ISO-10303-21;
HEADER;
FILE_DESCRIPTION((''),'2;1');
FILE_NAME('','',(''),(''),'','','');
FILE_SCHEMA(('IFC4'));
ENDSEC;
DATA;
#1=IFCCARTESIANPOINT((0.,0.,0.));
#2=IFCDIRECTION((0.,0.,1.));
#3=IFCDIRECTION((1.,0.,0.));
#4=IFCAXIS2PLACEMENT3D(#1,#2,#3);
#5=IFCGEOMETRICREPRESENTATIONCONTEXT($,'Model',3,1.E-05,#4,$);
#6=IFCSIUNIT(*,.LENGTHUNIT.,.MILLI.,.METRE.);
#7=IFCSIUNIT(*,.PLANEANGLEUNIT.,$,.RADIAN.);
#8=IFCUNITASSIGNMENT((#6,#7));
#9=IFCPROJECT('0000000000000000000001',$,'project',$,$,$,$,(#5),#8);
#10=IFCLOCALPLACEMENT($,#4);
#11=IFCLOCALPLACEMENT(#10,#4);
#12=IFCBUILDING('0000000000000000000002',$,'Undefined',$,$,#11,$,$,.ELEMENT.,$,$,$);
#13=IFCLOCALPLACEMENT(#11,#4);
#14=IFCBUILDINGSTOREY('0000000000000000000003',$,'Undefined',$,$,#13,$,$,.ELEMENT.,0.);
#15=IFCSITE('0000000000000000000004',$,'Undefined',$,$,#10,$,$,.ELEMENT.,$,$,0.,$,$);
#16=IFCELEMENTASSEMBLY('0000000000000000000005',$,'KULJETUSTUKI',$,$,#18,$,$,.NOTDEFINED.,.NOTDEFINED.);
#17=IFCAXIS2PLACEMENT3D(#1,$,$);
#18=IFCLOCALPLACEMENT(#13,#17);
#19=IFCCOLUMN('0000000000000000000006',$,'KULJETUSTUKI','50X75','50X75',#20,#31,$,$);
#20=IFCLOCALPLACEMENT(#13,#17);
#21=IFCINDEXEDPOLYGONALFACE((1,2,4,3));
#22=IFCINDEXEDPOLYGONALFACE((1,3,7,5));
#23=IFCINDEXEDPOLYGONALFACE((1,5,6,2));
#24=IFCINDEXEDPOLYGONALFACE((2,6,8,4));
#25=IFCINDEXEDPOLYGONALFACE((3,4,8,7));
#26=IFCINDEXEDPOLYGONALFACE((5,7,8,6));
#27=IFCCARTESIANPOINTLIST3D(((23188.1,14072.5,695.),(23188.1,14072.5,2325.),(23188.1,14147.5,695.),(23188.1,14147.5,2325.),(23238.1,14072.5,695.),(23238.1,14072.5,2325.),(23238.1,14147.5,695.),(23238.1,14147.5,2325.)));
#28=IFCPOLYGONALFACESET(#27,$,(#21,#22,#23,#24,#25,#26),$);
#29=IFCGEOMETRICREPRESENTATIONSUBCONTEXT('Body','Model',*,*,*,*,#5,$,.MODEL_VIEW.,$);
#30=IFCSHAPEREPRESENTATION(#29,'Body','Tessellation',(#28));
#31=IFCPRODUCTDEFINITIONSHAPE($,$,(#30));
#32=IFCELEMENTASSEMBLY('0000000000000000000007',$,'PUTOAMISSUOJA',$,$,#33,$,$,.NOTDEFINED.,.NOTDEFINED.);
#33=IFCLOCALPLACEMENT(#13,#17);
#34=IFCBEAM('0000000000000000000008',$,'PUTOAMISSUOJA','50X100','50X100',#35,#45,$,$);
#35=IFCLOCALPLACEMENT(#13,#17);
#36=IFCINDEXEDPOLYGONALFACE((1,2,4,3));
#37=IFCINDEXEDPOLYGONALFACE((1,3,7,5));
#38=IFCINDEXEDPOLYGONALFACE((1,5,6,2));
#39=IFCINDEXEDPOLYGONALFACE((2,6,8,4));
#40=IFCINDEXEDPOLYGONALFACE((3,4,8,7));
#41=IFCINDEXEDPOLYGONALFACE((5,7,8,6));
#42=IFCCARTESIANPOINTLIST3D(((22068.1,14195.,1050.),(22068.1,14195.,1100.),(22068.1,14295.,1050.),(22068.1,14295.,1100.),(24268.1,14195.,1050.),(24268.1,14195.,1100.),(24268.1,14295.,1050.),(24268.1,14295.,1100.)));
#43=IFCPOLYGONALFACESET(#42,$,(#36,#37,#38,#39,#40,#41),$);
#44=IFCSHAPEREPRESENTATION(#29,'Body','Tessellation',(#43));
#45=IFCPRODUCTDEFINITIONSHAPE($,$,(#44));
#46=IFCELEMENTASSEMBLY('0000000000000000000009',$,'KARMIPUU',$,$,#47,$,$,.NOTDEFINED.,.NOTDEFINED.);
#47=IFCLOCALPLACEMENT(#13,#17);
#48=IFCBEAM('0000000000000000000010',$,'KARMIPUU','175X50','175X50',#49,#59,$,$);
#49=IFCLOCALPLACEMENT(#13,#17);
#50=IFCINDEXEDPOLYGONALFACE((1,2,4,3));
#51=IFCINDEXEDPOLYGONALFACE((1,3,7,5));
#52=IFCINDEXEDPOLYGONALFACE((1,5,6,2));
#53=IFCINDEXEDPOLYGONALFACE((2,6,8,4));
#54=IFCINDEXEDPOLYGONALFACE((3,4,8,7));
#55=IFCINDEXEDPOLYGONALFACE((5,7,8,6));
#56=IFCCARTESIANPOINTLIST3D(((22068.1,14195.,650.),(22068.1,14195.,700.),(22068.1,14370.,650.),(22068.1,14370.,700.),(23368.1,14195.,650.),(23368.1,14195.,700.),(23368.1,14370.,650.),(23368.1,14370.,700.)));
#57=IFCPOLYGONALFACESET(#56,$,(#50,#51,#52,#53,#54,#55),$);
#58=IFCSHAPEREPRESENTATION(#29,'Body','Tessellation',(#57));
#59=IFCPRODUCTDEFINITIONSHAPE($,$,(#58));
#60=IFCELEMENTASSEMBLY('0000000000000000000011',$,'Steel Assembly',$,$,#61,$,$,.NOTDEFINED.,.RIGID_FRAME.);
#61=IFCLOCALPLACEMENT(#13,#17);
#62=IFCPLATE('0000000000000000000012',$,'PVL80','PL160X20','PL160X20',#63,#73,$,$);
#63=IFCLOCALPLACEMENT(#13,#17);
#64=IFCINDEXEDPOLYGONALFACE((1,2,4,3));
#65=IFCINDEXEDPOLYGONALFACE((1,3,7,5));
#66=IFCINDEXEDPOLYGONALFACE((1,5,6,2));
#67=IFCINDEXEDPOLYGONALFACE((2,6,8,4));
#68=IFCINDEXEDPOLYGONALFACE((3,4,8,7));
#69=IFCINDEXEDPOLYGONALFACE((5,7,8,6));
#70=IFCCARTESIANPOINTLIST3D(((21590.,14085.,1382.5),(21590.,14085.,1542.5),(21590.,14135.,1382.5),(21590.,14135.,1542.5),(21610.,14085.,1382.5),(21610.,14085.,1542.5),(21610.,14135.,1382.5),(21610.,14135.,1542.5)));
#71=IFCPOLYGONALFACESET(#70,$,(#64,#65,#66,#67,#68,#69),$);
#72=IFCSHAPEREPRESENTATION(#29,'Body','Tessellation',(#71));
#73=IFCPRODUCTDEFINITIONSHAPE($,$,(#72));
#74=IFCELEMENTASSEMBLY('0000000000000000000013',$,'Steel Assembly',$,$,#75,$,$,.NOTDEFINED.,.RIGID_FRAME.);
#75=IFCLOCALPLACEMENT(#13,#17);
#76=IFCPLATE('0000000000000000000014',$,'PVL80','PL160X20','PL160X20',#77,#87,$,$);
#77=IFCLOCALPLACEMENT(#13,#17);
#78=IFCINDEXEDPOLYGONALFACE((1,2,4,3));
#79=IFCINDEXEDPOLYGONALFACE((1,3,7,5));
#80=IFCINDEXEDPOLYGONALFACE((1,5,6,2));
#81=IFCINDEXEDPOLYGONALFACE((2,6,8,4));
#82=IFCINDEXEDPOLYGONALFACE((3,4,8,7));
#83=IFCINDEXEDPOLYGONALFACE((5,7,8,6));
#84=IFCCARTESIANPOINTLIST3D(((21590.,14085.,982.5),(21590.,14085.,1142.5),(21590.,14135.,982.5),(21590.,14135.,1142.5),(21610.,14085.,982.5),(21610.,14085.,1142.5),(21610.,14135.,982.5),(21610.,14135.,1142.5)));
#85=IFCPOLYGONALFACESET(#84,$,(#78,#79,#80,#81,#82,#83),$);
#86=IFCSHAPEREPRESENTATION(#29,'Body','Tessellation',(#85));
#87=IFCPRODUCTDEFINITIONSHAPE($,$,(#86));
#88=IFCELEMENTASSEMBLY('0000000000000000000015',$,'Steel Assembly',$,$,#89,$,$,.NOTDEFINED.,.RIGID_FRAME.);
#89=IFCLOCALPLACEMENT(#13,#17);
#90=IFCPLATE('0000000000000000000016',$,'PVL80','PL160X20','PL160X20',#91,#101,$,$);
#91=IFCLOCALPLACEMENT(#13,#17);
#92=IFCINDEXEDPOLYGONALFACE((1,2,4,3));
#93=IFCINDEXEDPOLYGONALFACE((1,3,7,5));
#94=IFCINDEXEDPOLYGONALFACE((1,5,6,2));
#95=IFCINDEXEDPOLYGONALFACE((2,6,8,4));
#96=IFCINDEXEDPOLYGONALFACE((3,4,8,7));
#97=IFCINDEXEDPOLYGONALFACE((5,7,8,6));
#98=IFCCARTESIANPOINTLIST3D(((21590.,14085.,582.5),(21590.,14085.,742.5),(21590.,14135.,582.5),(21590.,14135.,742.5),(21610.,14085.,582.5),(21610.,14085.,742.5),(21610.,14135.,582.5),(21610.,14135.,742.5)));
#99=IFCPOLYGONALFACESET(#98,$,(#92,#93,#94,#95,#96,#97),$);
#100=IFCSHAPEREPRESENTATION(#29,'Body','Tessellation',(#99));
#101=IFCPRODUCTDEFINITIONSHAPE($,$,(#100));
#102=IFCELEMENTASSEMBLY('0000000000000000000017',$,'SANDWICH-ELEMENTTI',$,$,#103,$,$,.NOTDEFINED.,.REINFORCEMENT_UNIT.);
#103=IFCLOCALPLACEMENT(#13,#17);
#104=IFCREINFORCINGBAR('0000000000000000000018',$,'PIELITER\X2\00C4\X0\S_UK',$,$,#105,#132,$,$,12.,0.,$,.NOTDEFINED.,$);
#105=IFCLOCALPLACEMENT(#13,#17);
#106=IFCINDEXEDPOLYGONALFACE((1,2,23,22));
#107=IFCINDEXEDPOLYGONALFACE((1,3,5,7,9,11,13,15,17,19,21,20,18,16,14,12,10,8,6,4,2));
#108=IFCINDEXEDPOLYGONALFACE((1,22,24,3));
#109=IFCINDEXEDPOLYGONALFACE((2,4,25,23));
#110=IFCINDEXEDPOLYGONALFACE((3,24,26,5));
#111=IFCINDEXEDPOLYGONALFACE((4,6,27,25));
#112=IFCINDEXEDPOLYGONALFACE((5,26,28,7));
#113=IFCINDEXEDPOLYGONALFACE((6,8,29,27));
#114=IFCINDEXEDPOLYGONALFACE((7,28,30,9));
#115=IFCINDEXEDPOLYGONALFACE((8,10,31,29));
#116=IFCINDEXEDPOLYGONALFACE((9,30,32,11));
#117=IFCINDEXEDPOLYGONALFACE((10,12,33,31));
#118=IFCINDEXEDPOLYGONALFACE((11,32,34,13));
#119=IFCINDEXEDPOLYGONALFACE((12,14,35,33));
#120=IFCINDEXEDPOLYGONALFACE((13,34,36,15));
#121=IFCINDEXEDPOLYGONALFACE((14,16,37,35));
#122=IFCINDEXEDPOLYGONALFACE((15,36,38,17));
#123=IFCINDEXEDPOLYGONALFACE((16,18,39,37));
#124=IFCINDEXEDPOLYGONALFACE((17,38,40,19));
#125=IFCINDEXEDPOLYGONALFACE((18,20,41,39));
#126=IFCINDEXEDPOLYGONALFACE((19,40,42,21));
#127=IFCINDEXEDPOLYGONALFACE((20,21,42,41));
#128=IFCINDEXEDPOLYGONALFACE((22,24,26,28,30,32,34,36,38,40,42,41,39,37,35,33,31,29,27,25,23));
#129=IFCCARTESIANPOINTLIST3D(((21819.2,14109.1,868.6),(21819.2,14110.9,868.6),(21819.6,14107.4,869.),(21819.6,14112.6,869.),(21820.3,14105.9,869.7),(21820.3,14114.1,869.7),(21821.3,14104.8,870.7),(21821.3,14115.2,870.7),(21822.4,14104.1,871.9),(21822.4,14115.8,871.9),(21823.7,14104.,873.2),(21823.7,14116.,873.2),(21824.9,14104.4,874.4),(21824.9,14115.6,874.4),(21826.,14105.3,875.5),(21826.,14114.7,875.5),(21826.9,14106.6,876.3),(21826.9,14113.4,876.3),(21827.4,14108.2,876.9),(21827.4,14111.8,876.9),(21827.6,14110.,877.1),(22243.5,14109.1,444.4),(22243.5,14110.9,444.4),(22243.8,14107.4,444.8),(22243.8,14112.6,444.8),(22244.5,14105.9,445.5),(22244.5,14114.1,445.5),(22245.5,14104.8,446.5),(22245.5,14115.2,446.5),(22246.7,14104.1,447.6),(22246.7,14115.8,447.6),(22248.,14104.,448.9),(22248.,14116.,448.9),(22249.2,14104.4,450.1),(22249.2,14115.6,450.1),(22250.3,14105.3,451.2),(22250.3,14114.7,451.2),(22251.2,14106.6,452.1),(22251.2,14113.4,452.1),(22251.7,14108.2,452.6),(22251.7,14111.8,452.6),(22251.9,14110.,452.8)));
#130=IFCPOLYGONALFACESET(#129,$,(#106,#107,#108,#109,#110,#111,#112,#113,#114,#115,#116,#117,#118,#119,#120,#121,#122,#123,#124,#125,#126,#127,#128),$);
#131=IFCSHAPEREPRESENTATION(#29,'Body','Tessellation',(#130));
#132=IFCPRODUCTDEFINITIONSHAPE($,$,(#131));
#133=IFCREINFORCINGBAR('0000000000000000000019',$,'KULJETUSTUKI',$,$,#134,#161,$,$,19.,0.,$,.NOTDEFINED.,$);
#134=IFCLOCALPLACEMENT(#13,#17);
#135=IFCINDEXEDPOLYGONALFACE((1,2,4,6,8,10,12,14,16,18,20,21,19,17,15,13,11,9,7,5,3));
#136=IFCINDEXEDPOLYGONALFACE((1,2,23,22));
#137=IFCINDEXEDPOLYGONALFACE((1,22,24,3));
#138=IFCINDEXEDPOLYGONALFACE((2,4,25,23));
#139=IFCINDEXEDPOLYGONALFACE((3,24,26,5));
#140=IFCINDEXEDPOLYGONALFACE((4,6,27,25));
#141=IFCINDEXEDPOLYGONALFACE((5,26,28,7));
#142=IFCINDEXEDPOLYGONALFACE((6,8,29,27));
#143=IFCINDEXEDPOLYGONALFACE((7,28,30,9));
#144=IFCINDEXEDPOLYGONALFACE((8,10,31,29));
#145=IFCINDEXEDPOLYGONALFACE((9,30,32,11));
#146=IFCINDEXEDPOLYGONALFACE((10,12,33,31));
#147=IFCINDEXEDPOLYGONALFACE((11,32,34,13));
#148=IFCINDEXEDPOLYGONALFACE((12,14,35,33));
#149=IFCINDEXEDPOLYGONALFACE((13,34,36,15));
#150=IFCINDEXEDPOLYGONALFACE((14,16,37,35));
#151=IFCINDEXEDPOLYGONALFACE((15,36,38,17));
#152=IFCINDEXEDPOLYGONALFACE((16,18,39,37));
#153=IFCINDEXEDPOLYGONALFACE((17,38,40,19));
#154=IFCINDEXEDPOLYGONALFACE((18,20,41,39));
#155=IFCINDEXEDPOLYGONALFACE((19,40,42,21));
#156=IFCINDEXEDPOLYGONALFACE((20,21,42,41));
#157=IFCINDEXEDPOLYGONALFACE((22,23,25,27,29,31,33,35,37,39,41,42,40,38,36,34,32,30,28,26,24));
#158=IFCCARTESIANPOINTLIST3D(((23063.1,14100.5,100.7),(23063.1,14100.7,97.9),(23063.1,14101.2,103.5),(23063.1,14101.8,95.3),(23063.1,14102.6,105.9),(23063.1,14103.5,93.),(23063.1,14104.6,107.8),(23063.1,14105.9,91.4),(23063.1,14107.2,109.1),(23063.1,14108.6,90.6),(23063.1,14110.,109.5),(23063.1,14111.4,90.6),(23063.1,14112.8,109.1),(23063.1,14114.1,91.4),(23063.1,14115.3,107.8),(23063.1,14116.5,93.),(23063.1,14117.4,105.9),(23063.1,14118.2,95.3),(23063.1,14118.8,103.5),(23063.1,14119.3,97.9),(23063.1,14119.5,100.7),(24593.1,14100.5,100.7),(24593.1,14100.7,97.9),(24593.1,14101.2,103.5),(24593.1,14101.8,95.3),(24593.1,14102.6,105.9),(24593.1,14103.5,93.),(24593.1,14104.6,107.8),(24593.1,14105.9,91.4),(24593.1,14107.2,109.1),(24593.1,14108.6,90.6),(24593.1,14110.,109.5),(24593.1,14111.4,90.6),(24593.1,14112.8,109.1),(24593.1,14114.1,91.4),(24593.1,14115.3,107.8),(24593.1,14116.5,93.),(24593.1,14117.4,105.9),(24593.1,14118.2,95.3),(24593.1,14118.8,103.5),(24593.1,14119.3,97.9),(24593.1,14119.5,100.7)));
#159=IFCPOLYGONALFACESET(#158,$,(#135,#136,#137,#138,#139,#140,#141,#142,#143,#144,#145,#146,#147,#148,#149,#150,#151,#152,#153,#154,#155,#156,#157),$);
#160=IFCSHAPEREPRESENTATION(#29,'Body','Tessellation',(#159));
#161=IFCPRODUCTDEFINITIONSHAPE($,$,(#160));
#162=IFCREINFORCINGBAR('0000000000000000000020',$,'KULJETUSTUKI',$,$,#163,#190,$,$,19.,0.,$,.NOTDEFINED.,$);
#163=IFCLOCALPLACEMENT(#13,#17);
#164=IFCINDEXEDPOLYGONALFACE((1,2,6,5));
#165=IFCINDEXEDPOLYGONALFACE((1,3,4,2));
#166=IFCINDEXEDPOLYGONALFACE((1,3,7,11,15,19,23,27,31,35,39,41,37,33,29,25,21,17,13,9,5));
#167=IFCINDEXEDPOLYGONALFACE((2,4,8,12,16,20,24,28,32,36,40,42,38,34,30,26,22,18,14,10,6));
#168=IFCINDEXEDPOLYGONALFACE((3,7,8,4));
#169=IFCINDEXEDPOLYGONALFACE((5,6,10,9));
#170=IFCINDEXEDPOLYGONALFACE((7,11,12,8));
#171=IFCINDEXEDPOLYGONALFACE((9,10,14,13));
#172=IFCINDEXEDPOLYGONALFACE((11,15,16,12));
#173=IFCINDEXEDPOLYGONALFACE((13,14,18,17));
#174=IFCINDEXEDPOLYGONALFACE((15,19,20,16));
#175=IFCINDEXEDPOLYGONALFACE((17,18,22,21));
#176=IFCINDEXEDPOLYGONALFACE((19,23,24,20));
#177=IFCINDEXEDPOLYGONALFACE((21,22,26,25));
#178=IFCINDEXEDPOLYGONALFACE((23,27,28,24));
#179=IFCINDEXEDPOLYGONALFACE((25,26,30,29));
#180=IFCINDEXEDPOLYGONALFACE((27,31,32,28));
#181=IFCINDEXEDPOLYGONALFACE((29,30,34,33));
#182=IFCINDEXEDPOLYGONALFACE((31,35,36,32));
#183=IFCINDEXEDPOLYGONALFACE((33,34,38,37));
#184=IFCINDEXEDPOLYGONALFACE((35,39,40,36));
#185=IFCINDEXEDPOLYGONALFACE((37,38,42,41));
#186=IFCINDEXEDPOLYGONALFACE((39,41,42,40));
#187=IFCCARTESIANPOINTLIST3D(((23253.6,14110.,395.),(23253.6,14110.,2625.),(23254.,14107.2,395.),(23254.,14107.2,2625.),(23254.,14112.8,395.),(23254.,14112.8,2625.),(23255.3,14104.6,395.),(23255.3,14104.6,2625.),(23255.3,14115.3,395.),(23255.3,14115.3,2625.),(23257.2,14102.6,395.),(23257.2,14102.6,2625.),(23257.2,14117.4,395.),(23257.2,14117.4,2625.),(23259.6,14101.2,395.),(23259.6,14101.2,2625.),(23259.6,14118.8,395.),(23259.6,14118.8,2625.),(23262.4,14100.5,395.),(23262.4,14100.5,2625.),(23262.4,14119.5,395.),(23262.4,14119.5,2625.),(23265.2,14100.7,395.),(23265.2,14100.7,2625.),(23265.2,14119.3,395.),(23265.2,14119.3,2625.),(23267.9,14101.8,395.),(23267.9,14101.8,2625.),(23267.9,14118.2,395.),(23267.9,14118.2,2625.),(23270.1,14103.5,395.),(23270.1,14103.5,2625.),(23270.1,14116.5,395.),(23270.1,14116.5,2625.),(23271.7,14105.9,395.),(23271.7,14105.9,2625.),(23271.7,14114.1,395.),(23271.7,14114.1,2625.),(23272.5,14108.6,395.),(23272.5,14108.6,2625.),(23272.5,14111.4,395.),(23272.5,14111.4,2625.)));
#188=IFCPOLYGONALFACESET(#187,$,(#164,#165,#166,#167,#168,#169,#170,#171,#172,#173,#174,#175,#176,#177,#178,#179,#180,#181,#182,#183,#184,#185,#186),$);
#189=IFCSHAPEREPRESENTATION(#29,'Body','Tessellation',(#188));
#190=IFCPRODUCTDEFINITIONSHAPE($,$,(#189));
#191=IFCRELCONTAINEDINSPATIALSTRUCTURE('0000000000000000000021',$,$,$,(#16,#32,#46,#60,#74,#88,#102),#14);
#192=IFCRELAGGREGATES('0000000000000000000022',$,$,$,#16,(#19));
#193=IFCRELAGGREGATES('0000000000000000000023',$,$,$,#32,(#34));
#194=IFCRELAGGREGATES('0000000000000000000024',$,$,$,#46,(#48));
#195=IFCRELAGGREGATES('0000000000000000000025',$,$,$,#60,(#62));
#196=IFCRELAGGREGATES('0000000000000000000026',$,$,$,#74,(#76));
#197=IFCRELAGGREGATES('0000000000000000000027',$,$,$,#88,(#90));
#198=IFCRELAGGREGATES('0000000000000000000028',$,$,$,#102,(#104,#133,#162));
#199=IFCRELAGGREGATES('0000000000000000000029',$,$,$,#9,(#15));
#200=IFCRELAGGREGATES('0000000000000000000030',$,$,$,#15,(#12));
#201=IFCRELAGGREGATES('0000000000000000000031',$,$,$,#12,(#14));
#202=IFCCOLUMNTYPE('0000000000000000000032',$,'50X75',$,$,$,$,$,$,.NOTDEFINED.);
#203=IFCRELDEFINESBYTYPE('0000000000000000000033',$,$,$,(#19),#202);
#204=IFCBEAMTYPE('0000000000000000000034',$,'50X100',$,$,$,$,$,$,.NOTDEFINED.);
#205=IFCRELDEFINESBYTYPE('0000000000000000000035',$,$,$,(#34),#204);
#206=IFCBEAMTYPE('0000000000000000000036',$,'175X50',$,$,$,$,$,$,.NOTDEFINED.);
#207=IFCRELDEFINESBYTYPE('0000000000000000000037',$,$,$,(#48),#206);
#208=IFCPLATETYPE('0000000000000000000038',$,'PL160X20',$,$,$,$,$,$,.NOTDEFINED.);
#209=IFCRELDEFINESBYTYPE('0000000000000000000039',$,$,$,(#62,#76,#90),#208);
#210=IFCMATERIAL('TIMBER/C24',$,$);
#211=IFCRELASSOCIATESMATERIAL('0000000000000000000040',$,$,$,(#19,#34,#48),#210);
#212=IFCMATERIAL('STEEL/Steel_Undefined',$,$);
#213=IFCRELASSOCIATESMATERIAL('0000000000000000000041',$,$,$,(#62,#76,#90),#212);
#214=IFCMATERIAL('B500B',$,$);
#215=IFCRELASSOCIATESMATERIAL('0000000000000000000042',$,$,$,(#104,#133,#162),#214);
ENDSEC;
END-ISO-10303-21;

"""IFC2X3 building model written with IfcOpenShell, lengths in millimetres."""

from ifc_helpers import new_model, entity, si_unit, frame, origin_with_axes, origin_2d_with_axis, place, context, subcontext, project, spatial, polyline, rectangle, outline, extrude, source, transform, mapped, material, type_object, element, aggregate, save


model = new_model("IFC2X3")

# Units and contexts
model_context = context("Model", 3, precision=1e-05, world=origin_with_axes())
body_context = subcontext(model_context, "Body", "Model", "MODEL_VIEW")
ifc_project = project(units=[si_unit("LENGTHUNIT", "METRE", prefix="MILLI"), si_unit("PLANEANGLEUNIT", "RADIAN")], contexts=[model_context])

# Site, building, storey
site_placement = place(None, origin_with_axes())
site = spatial("IfcSite", under=ifc_project, at=site_placement, Name="Undefined", CompositionType="ELEMENT", RefElevation=0.0)
building_placement = place(site_placement, origin_with_axes())
building = spatial("IfcBuilding", under=site, at=building_placement, Name="Undefined", CompositionType="ELEMENT")
storey_placement = place(building_placement, origin_with_axes())
storey = spatial("IfcBuildingStorey", under=building, at=storey_placement, Name="Undefined", CompositionType="ELEMENT", Elevation=0.0)

# Element assembly, column
assembly_1_placement = place(storey_placement, origin_with_axes())
assembly_1 = element("IfcElementAssembly", 1, at=assembly_1_placement, inside=storey, Name="KULJETUSTUKI", AssemblyPlace="NOTDEFINED", PredefinedType="NOTDEFINED")
ifc_material_1 = material(Name="TIMBER/C24")
column_type = type_object("IfcColumnType", Name="50X75", PredefinedType="NOTDEFINED")
column_placement = place(assembly_1_placement, frame((23213.1, 14110.0, 695.0), z_axis=(0.0, 0.0, 1.0), x_axis=(-1.0, 0.0, 0.0)))
column = element("IfcColumn", 2, at=column_placement, type_object=column_type, material=ifc_material_1, Name="KULJETUSTUKI", Description="50X75", ObjectType="50X75", context=body_context, shape_type="SweptSolid", body=[
    extrude(rectangle(XDim=75.0, YDim=50.0, at=origin_2d_with_axis()), frame((0.0, 0.0, 1630.0), z_axis=(0.0, 0.0, -1.0), x_axis=(0.0, 1.0, 0.0)), (0.0, 0.0, 1.0), 1630.0),
])
aggregate(assembly_1, [column])

# Element assemblies, beams
assembly_2_placement = place(storey_placement, origin_with_axes())
assembly_2 = element("IfcElementAssembly", 3, at=assembly_2_placement, inside=storey, Name="PUTOAMISSUOJA", AssemblyPlace="NOTDEFINED", PredefinedType="NOTDEFINED")
beam_type_1 = type_object("IfcBeamType", Name="50X100", PredefinedType="NOTDEFINED")
beam_1_placement = place(assembly_2_placement, frame((22068.1, 14245.0, 1075.0), z_axis=(0.0, 0.0, 1.0), x_axis=(1.0, 0.0, 0.0)))
beam_1 = element("IfcBeam", 4, at=beam_1_placement, type_object=beam_type_1, material=ifc_material_1, Name="PUTOAMISSUOJA", Description="50X100", ObjectType="50X100", context=body_context, shape_type="SweptSolid", body=[
    extrude(rectangle(XDim=100.0, YDim=50.0, at=origin_2d_with_axis()), frame((2200.0, 0.0, 0.0), z_axis=(-1.0, 0.0, 0.0), x_axis=(0.0, -1.0, 0.0)), (0.0, 0.0, 1.0), 2200.0),
])
aggregate(assembly_2, [beam_1])
assembly_3_placement = place(storey_placement, origin_with_axes())
assembly_3 = element("IfcElementAssembly", 5, at=assembly_3_placement, inside=storey, Name="KARMIPUU", AssemblyPlace="NOTDEFINED", PredefinedType="NOTDEFINED")
beam_type_2 = type_object("IfcBeamType", Name="175X50", PredefinedType="NOTDEFINED")
beam_2_placement = place(assembly_3_placement, frame((22068.1, 14282.5, 675.0), z_axis=(0.0, -1.0, 0.0), x_axis=(1.0, 0.0, 0.0)))
beam_2 = element("IfcBeam", 6, at=beam_2_placement, type_object=beam_type_2, material=ifc_material_1, Name="KARMIPUU", Description="175X50", ObjectType="175X50", context=body_context, shape_type="SweptSolid", body=[
    extrude(rectangle(XDim=50.0, YDim=175.0, at=origin_2d_with_axis()), frame((1300.0, 0.0, 0.0), z_axis=(-1.0, 0.0, 0.0), x_axis=(0.0, -1.0, 0.0)), (0.0, 0.0, 1.0), 1300.0),
])
aggregate(assembly_3, [beam_2])

# Element assemblies, plates
assembly_4_placement = place(storey_placement, origin_with_axes())
assembly_4 = element("IfcElementAssembly", 7, at=assembly_4_placement, inside=storey, Name="Steel Assembly", AssemblyPlace="NOTDEFINED", PredefinedType="RIGID_FRAME")
ifc_material_2 = material(Name="STEEL/Steel_Undefined")
plate_type = type_object("IfcPlateType", Name="PL160X20", PredefinedType="NOTDEFINED")
plate_1_placement = place(assembly_4_placement, frame((21590.0, 14085.0, 1462.5), z_axis=(0.0, 0.0, -1.0), x_axis=(0.0, 1.0, 0.0)))
plate_1 = element("IfcPlate", 8, at=plate_1_placement, type_object=plate_type, material=ifc_material_2, Name="PVL80", Description="PL160X20", ObjectType="PL160X20", context=body_context, shape_type="SweptSolid", body=[
    extrude(outline(polyline([(0.0, 0.0), (50.0, 0.0), (50.0, 20.0), (0.0, 20.0), (0.0, 0.0)])), frame((0.0, 0.0, -80.0), z_axis=(0.0, 0.0, 1.0), x_axis=(1.0, 0.0, 0.0)), (0.0, 0.0, 1.0), 160.0),
])
assembly_5_placement = place(storey_placement, origin_with_axes())
assembly_5 = element("IfcElementAssembly", 9, at=assembly_5_placement, inside=storey, Name="Steel Assembly", AssemblyPlace="NOTDEFINED", PredefinedType="RIGID_FRAME")
plate_2_placement = place(assembly_5_placement, frame((21590.0, 14085.0, 1062.5), z_axis=(0.0, 0.0, -1.0), x_axis=(0.0, 1.0, 0.0)))
plate_2 = element("IfcPlate", 10, at=plate_2_placement, type_object=plate_type, material=ifc_material_2, Name="PVL80", Description="PL160X20", ObjectType="PL160X20", context=body_context, shape_type="SweptSolid", body=[
    extrude(outline(polyline([(0.0, 0.0), (50.0, 0.0), (50.0, 20.0), (0.0, 20.0), (0.0, 0.0)])), frame((0.0, 0.0, -80.0), z_axis=(0.0, 0.0, 1.0), x_axis=(1.0, 0.0, 0.0)), (0.0, 0.0, 1.0), 160.0),
])
assembly_6_placement = place(storey_placement, origin_with_axes())
assembly_6 = element("IfcElementAssembly", 11, at=assembly_6_placement, inside=storey, Name="Steel Assembly", AssemblyPlace="NOTDEFINED", PredefinedType="RIGID_FRAME")
plate_3_placement = place(assembly_6_placement, frame((21590.0, 14085.0, 662.5), z_axis=(0.0, 0.0, -1.0), x_axis=(0.0, 1.0, 0.0)))
plate_3 = element("IfcPlate", 12, at=plate_3_placement, type_object=plate_type, material=ifc_material_2, Name="PVL80", Description="PL160X20", ObjectType="PL160X20", context=body_context, shape_type="SweptSolid", body=[
    extrude(outline(polyline([(0.0, 0.0), (50.0, 0.0), (50.0, 20.0), (0.0, 20.0), (0.0, 0.0)])), frame((0.0, 0.0, -80.0), z_axis=(0.0, 0.0, 1.0), x_axis=(1.0, 0.0, 0.0)), (0.0, 0.0, 1.0), 160.0),
])

# Element assembly
assembly_7_placement = place(storey_placement, origin_with_axes())
assembly_7 = element("IfcElementAssembly", 13, at=assembly_7_placement, inside=storey, Name="SANDWICH-ELEMENTTI", AssemblyPlace="NOTDEFINED", PredefinedType="REINFORCEMENT_UNIT")

# Reinforcing bars
aggregate(assembly_4, [plate_1])
aggregate(assembly_5, [plate_2])
aggregate(assembly_6, [plate_3])
ifc_material_3 = material(Name="B500B")
shared_shape_1 = source(origin_with_axes(), body_context, "Body", "AdvancedSweptSolid", [
    entity("IfcSweptDiskSolid", entity("IfcTrimmedCurve", entity("IfcLine", entity("IfcCartesianPoint", [0.0, 0.0, 0.0]), entity("IfcVector", entity("IfcDirection", [1.0, 0.0, 0.0]), 1.0)), [entity("IfcParameterValue", 0.0)], [entity("IfcParameterValue", 600.0)], True, "PARAMETER"), 6.0, None, 0.0, 600.0),
])
reinforcing_bar_1_placement = place(assembly_7_placement, frame((22694.5, 14110.0, 1.7), z_axis=(0.707107, 0.0, 0.707107), x_axis=(-0.707107, 0.0, 0.707107)))
reinforcing_bar_1 = element("IfcReinforcingBar", 14, at=reinforcing_bar_1_placement, material=ifc_material_3, Name="PIELITERÄS_UK", BarRole="NOTDEFINED", CrossSectionArea=0.0, NominalDiameter=12.0, context=body_context, shape_type="MappedRepresentation", body=[
    mapped(shared_shape_1, transform((632.0, 0.0, 0.0))),
])
shared_shape_2 = source(origin_with_axes(), body_context, "Body", "AdvancedSweptSolid", [
    entity("IfcSweptDiskSolid", entity("IfcTrimmedCurve", entity("IfcLine", entity("IfcCartesianPoint", [0.0, 0.0, 0.0]), entity("IfcVector", entity("IfcDirection", [1.0, 0.0, 0.0]), 1.0)), [entity("IfcParameterValue", 0.0)], [entity("IfcParameterValue", 1530.0)], True, "PARAMETER"), 9.5, None, 0.0, 1530.0),
])
reinforcing_bar_2_placement = place(assembly_7_placement, frame((23063.1, 14110.0, 100.0), z_axis=(0.0, 0.0, 1.0), x_axis=(1.0, 0.0, 0.0)))
reinforcing_bar_2 = element("IfcReinforcingBar", 15, at=reinforcing_bar_2_placement, material=ifc_material_3, Name="KULJETUSTUKI", BarRole="NOTDEFINED", CrossSectionArea=0.0, NominalDiameter=19.0, context=body_context, shape_type="MappedRepresentation", body=[
    mapped(shared_shape_2, transform((0.0, 0.0, 0.0))),
])
shared_shape_3 = source(origin_with_axes(), body_context, "Body", "AdvancedSweptSolid", [
    entity("IfcSweptDiskSolid", entity("IfcTrimmedCurve", entity("IfcLine", entity("IfcCartesianPoint", [0.0, 0.0, 0.0]), entity("IfcVector", entity("IfcDirection", [1.0, 0.0, 0.0]), 1.0)), [entity("IfcParameterValue", 0.0)], [entity("IfcParameterValue", 2230.0)], True, "PARAMETER"), 9.5, None, 0.0, 2230.0),
])
reinforcing_bar_3_placement = place(assembly_7_placement, frame((23263.1, 14110.0, 395.0), z_axis=(-1.0, 0.0, 0.0), x_axis=(0.0, 0.0, 1.0)))
reinforcing_bar_3 = element("IfcReinforcingBar", 16, at=reinforcing_bar_3_placement, material=ifc_material_3, Name="KULJETUSTUKI", BarRole="NOTDEFINED", CrossSectionArea=0.0, NominalDiameter=19.0, context=body_context, shape_type="MappedRepresentation", body=[
    mapped(shared_shape_3, transform((0.0, 0.0, 0.0))),
])
aggregate(assembly_7, [reinforcing_bar_1, reinforcing_bar_2, reinforcing_bar_3])

save(model, "model.ifc")
